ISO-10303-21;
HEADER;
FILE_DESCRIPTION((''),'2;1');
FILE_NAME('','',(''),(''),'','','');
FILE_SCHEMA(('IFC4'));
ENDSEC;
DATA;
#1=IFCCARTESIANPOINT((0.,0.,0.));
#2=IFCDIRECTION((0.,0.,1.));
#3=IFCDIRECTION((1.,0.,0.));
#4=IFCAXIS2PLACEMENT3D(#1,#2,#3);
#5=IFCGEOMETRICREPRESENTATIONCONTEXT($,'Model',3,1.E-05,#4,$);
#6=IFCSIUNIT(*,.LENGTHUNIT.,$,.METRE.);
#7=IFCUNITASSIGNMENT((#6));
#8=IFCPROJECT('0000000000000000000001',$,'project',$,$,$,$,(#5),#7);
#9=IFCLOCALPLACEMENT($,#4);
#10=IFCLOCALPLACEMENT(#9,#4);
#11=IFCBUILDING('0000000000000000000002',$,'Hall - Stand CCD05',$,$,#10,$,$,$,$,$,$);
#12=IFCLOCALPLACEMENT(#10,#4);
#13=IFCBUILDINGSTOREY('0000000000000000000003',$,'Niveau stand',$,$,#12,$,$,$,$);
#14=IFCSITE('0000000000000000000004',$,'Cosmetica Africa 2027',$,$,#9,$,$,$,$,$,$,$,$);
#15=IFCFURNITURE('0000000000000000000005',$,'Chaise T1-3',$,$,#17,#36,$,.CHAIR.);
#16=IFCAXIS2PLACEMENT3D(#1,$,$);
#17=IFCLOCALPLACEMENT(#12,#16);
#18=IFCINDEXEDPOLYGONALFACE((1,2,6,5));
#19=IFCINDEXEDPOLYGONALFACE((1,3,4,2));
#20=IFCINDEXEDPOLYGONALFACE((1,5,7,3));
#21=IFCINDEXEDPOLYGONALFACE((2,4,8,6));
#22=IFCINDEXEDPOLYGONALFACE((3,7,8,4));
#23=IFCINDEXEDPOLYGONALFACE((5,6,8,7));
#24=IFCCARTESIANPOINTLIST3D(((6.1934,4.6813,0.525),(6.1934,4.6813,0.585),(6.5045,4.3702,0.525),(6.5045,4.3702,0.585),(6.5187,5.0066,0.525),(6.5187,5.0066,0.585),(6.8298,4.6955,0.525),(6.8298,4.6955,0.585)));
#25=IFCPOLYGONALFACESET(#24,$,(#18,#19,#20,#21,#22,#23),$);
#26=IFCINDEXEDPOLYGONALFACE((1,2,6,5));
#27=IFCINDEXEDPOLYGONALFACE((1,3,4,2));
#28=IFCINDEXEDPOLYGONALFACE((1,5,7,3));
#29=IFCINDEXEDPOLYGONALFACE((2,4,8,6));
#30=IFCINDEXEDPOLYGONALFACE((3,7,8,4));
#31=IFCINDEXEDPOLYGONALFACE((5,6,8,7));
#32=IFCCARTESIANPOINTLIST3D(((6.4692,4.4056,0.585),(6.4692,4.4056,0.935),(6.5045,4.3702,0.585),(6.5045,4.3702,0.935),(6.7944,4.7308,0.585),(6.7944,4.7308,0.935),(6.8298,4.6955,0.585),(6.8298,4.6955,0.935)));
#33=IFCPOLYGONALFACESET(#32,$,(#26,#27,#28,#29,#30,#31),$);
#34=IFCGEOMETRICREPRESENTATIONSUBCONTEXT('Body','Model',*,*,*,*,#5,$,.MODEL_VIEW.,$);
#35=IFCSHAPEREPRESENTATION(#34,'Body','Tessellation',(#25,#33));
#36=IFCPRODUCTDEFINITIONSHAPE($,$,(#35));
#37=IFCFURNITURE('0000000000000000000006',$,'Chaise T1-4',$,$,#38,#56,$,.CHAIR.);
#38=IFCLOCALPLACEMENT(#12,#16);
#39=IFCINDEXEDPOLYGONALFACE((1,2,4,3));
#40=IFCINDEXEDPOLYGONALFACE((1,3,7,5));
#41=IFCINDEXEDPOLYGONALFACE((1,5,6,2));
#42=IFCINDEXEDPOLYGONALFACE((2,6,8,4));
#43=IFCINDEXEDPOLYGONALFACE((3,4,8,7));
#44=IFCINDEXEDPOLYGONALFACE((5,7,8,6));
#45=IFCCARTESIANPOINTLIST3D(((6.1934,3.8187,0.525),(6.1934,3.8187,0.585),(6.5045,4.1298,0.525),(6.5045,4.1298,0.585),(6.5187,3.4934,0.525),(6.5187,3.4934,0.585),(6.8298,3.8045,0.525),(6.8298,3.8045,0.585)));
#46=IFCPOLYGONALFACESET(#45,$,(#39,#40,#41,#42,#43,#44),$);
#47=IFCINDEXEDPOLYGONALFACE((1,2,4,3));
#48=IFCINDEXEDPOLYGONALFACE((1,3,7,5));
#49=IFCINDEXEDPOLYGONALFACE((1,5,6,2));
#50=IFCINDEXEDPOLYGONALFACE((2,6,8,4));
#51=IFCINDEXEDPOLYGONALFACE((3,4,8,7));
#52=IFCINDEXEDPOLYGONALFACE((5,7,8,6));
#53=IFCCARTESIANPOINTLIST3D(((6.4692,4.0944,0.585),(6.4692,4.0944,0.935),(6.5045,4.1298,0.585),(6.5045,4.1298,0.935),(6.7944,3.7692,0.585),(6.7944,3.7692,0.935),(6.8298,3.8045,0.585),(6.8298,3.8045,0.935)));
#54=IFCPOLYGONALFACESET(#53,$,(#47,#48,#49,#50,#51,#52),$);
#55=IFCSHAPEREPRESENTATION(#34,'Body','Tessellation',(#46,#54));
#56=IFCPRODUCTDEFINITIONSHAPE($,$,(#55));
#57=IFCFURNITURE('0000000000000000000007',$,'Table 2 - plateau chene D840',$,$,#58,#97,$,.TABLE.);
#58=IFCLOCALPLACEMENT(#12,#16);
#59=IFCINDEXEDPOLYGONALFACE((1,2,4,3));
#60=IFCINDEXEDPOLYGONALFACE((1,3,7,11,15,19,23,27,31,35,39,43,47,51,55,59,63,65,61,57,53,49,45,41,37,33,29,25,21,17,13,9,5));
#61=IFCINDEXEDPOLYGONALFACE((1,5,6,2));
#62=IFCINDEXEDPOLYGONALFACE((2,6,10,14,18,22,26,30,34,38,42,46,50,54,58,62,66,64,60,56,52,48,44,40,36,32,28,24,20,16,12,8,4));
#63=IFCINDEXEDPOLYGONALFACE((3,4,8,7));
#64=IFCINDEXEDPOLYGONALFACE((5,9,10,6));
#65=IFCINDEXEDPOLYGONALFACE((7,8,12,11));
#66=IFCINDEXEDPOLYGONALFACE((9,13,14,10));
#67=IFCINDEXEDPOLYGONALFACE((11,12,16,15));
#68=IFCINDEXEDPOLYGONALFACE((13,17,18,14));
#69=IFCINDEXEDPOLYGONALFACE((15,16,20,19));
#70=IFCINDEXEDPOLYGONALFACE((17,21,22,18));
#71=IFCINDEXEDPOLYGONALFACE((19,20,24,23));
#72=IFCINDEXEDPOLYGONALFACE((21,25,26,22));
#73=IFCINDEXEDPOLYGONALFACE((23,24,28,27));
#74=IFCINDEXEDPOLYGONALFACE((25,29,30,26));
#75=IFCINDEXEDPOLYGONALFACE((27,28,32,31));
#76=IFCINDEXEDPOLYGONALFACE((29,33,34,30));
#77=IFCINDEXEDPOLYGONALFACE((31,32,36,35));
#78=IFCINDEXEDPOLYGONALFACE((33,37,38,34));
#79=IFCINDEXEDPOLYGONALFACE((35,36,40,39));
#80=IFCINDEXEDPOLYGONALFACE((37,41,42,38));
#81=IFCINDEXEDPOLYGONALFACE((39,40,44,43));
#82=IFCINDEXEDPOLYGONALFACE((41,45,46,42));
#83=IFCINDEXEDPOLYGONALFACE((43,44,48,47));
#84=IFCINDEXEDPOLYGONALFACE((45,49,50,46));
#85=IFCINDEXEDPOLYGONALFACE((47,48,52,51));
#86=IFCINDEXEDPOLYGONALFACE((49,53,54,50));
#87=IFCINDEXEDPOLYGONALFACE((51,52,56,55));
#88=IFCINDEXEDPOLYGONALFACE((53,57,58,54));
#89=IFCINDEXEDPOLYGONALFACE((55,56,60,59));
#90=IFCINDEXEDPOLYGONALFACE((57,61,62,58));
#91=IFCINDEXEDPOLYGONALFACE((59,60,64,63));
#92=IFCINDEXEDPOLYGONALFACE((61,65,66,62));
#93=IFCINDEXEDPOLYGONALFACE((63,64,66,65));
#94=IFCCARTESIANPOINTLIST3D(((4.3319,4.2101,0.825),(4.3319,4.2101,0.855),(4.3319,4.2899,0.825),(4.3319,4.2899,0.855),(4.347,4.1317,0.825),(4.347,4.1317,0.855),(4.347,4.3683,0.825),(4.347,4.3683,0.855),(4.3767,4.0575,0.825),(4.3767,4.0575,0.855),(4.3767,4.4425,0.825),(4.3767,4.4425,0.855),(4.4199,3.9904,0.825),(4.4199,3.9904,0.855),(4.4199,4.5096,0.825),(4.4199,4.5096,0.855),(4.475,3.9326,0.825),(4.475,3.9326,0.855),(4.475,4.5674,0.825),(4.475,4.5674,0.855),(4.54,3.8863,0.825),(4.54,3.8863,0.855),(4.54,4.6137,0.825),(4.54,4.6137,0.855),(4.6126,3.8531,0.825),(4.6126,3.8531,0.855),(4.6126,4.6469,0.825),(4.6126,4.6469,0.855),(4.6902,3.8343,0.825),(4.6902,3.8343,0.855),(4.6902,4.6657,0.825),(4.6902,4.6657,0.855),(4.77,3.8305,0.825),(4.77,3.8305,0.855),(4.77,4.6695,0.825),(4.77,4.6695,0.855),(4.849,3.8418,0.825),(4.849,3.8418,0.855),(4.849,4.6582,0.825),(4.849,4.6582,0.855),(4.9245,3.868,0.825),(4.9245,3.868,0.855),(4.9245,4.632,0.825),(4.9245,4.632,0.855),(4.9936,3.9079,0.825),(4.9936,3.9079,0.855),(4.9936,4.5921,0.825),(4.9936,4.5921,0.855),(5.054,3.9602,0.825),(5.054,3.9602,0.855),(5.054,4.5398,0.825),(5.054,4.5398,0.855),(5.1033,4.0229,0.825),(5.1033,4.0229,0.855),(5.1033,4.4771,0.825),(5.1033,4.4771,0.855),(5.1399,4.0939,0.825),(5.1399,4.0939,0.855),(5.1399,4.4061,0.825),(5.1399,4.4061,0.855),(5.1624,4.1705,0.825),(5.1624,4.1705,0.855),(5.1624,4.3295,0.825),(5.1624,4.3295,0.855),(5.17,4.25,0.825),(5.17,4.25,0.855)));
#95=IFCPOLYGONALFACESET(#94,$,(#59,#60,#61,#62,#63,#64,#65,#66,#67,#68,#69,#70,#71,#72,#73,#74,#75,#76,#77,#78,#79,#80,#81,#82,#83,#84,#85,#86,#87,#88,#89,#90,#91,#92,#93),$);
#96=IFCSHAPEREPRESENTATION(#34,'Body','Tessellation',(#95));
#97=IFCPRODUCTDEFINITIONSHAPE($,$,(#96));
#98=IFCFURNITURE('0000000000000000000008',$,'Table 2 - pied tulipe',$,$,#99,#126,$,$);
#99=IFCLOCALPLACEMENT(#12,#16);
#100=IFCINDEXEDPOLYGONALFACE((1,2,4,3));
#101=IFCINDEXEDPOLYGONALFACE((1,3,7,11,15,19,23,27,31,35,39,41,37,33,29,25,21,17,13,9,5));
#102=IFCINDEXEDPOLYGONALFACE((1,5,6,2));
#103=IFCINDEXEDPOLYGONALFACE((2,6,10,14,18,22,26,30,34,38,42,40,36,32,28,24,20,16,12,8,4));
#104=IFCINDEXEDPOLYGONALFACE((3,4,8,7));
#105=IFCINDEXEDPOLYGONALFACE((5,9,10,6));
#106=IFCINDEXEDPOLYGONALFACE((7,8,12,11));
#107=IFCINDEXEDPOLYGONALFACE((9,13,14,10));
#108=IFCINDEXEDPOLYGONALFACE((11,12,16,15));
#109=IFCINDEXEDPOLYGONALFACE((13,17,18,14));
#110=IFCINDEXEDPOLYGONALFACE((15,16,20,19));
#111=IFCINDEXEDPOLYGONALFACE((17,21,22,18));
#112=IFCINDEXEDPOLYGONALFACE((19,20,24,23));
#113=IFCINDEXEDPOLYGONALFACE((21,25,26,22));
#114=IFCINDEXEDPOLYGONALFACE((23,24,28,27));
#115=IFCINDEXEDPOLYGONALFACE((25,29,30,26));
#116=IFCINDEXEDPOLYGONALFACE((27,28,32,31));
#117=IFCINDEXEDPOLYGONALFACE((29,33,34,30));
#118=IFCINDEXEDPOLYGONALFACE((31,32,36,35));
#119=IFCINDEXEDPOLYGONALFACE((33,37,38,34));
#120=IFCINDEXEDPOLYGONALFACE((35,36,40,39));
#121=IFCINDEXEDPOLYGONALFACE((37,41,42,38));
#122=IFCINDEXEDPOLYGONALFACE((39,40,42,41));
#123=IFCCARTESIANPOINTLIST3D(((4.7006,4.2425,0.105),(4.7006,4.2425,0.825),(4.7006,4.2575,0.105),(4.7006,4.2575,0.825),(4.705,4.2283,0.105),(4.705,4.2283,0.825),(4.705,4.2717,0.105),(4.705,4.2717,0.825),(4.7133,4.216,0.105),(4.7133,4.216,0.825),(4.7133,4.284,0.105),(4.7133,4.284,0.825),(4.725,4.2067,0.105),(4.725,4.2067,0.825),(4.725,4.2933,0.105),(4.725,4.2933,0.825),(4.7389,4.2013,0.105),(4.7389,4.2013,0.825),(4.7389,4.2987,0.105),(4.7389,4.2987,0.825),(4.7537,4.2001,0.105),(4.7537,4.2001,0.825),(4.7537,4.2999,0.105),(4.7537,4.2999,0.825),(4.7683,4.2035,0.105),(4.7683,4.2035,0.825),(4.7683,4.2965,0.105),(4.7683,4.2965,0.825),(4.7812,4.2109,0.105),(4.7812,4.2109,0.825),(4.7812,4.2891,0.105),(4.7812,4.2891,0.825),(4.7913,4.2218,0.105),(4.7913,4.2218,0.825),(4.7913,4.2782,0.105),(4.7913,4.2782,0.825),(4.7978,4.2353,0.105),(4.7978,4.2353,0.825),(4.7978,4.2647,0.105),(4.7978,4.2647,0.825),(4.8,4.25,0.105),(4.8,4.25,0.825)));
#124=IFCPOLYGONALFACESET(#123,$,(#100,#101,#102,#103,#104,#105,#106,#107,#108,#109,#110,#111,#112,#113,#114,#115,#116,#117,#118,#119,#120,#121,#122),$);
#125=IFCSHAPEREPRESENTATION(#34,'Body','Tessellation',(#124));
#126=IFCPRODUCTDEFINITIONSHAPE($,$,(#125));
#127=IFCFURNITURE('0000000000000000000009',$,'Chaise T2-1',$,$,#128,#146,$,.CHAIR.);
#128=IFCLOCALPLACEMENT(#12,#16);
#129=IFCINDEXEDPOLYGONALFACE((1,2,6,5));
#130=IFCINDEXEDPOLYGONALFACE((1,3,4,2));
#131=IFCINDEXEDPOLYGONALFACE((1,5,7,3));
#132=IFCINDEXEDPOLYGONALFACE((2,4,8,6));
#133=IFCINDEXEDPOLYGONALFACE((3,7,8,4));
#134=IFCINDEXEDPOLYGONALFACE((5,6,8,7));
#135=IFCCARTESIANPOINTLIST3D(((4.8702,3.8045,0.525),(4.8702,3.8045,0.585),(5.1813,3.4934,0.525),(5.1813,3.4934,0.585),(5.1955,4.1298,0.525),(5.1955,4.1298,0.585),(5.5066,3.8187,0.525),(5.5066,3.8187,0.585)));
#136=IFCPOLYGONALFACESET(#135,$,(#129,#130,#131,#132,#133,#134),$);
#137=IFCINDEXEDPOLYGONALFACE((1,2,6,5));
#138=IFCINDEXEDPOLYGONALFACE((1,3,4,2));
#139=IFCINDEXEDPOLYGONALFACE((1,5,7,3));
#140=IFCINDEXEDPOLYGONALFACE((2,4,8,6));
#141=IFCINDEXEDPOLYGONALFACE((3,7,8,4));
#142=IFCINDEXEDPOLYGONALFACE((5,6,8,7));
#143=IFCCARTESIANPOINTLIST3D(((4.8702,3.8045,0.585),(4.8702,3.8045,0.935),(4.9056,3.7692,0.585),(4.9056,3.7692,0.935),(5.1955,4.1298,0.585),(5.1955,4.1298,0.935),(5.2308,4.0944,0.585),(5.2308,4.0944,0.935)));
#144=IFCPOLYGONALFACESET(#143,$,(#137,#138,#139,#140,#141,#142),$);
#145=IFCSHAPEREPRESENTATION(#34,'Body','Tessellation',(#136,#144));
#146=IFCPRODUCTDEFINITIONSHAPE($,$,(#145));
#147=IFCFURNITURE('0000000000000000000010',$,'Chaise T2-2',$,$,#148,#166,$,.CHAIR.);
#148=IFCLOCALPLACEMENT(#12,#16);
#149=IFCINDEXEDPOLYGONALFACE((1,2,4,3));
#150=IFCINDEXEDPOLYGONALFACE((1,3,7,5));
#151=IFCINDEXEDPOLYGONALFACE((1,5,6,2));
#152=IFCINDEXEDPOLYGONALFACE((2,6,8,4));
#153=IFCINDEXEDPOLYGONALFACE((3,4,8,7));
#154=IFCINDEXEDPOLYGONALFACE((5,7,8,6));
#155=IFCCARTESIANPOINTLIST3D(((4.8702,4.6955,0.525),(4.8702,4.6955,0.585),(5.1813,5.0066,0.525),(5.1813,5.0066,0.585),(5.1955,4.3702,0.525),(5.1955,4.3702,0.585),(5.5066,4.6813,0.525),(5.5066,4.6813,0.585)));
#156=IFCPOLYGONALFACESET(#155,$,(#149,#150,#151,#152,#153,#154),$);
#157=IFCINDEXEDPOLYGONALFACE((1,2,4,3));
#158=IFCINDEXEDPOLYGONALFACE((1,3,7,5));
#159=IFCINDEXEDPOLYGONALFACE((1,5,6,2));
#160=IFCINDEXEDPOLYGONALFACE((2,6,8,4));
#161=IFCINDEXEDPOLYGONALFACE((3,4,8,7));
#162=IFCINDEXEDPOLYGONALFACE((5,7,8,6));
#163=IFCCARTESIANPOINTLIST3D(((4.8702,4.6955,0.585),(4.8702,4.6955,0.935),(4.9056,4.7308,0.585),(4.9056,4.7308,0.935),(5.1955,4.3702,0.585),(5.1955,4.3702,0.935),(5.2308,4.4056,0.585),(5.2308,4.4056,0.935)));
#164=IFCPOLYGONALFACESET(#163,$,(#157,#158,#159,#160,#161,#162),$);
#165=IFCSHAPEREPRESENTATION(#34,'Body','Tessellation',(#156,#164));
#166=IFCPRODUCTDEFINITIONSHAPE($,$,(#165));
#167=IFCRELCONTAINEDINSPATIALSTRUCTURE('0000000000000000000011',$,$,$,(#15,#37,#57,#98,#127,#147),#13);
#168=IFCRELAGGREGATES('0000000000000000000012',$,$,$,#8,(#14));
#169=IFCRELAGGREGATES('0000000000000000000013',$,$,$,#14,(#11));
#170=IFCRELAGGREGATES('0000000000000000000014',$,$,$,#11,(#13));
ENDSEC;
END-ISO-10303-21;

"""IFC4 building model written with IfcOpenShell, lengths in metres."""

from ifc_helpers import new_model, si_unit, frame, frame_2d, origin_with_axes, place, context, subcontext, project, spatial, polyline, circle, outline, extrude, element, save


model = new_model("IFC4")

# Units and contexts
model_context = context("Model", 3, precision=1e-05, world=origin_with_axes())
body_context = subcontext(model_context, "Body", "Model", "MODEL_VIEW")
ifc_project = project(units=[si_unit("LENGTHUNIT", "METRE")], contexts=[model_context])

# Site, building, storey
site_placement = place(None, origin_with_axes())
site = spatial("IfcSite", under=ifc_project, at=site_placement, Name="Cosmetica Africa 2027")
building_placement = place(site_placement, origin_with_axes())
building = spatial("IfcBuilding", under=site, at=building_placement, Name="Hall - Stand CCD05")
storey_placement = place(building_placement, origin_with_axes())
storey = spatial("IfcBuildingStorey", under=building, at=storey_placement, Name="Niveau stand")

# Furniture
furniture_1_placement = place(storey_placement, origin_with_axes())
element("IfcFurniture", 1, at=furniture_1_placement, inside=storey, Name="Chaise T1-3", PredefinedType="CHAIR", context=body_context, shape_type="SweptSolid", body=[
    extrude(outline(polyline([(6.5187, 5.0066), (6.1934, 4.6813), (6.5045, 4.3702), (6.8298, 4.6955), (6.5187, 5.0066)])), frame((0.0, 0.0, 0.525)), (0.0, 0.0, 1.0), 0.06),
    extrude(outline(polyline([(6.7944, 4.7308), (6.4692, 4.4056), (6.5045, 4.3702), (6.8298, 4.6955), (6.7944, 4.7308)])), frame((0.0, 0.0, 0.585)), (0.0, 0.0, 1.0), 0.35),
])
furniture_2_placement = place(storey_placement, origin_with_axes())
element("IfcFurniture", 2, at=furniture_2_placement, inside=storey, Name="Chaise T1-4", PredefinedType="CHAIR", context=body_context, shape_type="SweptSolid", body=[
    extrude(outline(polyline([(6.1934, 3.8187), (6.5187, 3.4934), (6.8298, 3.8045), (6.5045, 4.1298), (6.1934, 3.8187)])), frame((0.0, 0.0, 0.525)), (0.0, 0.0, 1.0), 0.06),
    extrude(outline(polyline([(6.4692, 4.0944), (6.7944, 3.7692), (6.8298, 3.8045), (6.5045, 4.1298), (6.4692, 4.0944)])), frame((0.0, 0.0, 0.585)), (0.0, 0.0, 1.0), 0.35),
])
furniture_3_placement = place(storey_placement, origin_with_axes())
element("IfcFurniture", 3, at=furniture_3_placement, inside=storey, Name="Table 2 - plateau chene D840", PredefinedType="TABLE", context=body_context, shape_type="SweptSolid", body=[
    extrude(circle(Radius=0.42, at=frame_2d((4.75, 4.25))), frame((0.0, 0.0, 0.825)), (0.0, 0.0, 1.0), 0.03),
])
furniture_4_placement = place(storey_placement, origin_with_axes())
element("IfcFurniture", 4, at=furniture_4_placement, inside=storey, Name="Table 2 - pied tulipe", context=body_context, shape_type="SweptSolid", body=[
    extrude(circle(Radius=0.05, at=frame_2d((4.75, 4.25))), frame((0.0, 0.0, 0.105)), (0.0, 0.0, 1.0), 0.72),
])
furniture_5_placement = place(storey_placement, origin_with_axes())
element("IfcFurniture", 5, at=furniture_5_placement, inside=storey, Name="Chaise T2-1", PredefinedType="CHAIR", context=body_context, shape_type="SweptSolid", body=[
    extrude(outline(polyline([(5.1813, 3.4934), (5.5066, 3.8187), (5.1955, 4.1298), (4.8702, 3.8045), (5.1813, 3.4934)])), frame((0.0, 0.0, 0.525)), (0.0, 0.0, 1.0), 0.06),
    extrude(outline(polyline([(4.9056, 3.7692), (5.2308, 4.0944), (5.1955, 4.1298), (4.8702, 3.8045), (4.9056, 3.7692)])), frame((0.0, 0.0, 0.585)), (0.0, 0.0, 1.0), 0.35),
])
furniture_6_placement = place(storey_placement, origin_with_axes())
element("IfcFurniture", 6, at=furniture_6_placement, inside=storey, Name="Chaise T2-2", PredefinedType="CHAIR", context=body_context, shape_type="SweptSolid", body=[
    extrude(outline(polyline([(5.5066, 4.6813), (5.1813, 5.0066), (4.8702, 4.6955), (5.1955, 4.3702), (5.5066, 4.6813)])), frame((0.0, 0.0, 0.525)), (0.0, 0.0, 1.0), 0.06),
    extrude(outline(polyline([(5.2308, 4.4056), (4.9056, 4.7308), (4.8702, 4.6955), (5.1955, 4.3702), (5.2308, 4.4056)])), frame((0.0, 0.0, 0.585)), (0.0, 0.0, 1.0), 0.35),
])

save(model, "model.ifc")
